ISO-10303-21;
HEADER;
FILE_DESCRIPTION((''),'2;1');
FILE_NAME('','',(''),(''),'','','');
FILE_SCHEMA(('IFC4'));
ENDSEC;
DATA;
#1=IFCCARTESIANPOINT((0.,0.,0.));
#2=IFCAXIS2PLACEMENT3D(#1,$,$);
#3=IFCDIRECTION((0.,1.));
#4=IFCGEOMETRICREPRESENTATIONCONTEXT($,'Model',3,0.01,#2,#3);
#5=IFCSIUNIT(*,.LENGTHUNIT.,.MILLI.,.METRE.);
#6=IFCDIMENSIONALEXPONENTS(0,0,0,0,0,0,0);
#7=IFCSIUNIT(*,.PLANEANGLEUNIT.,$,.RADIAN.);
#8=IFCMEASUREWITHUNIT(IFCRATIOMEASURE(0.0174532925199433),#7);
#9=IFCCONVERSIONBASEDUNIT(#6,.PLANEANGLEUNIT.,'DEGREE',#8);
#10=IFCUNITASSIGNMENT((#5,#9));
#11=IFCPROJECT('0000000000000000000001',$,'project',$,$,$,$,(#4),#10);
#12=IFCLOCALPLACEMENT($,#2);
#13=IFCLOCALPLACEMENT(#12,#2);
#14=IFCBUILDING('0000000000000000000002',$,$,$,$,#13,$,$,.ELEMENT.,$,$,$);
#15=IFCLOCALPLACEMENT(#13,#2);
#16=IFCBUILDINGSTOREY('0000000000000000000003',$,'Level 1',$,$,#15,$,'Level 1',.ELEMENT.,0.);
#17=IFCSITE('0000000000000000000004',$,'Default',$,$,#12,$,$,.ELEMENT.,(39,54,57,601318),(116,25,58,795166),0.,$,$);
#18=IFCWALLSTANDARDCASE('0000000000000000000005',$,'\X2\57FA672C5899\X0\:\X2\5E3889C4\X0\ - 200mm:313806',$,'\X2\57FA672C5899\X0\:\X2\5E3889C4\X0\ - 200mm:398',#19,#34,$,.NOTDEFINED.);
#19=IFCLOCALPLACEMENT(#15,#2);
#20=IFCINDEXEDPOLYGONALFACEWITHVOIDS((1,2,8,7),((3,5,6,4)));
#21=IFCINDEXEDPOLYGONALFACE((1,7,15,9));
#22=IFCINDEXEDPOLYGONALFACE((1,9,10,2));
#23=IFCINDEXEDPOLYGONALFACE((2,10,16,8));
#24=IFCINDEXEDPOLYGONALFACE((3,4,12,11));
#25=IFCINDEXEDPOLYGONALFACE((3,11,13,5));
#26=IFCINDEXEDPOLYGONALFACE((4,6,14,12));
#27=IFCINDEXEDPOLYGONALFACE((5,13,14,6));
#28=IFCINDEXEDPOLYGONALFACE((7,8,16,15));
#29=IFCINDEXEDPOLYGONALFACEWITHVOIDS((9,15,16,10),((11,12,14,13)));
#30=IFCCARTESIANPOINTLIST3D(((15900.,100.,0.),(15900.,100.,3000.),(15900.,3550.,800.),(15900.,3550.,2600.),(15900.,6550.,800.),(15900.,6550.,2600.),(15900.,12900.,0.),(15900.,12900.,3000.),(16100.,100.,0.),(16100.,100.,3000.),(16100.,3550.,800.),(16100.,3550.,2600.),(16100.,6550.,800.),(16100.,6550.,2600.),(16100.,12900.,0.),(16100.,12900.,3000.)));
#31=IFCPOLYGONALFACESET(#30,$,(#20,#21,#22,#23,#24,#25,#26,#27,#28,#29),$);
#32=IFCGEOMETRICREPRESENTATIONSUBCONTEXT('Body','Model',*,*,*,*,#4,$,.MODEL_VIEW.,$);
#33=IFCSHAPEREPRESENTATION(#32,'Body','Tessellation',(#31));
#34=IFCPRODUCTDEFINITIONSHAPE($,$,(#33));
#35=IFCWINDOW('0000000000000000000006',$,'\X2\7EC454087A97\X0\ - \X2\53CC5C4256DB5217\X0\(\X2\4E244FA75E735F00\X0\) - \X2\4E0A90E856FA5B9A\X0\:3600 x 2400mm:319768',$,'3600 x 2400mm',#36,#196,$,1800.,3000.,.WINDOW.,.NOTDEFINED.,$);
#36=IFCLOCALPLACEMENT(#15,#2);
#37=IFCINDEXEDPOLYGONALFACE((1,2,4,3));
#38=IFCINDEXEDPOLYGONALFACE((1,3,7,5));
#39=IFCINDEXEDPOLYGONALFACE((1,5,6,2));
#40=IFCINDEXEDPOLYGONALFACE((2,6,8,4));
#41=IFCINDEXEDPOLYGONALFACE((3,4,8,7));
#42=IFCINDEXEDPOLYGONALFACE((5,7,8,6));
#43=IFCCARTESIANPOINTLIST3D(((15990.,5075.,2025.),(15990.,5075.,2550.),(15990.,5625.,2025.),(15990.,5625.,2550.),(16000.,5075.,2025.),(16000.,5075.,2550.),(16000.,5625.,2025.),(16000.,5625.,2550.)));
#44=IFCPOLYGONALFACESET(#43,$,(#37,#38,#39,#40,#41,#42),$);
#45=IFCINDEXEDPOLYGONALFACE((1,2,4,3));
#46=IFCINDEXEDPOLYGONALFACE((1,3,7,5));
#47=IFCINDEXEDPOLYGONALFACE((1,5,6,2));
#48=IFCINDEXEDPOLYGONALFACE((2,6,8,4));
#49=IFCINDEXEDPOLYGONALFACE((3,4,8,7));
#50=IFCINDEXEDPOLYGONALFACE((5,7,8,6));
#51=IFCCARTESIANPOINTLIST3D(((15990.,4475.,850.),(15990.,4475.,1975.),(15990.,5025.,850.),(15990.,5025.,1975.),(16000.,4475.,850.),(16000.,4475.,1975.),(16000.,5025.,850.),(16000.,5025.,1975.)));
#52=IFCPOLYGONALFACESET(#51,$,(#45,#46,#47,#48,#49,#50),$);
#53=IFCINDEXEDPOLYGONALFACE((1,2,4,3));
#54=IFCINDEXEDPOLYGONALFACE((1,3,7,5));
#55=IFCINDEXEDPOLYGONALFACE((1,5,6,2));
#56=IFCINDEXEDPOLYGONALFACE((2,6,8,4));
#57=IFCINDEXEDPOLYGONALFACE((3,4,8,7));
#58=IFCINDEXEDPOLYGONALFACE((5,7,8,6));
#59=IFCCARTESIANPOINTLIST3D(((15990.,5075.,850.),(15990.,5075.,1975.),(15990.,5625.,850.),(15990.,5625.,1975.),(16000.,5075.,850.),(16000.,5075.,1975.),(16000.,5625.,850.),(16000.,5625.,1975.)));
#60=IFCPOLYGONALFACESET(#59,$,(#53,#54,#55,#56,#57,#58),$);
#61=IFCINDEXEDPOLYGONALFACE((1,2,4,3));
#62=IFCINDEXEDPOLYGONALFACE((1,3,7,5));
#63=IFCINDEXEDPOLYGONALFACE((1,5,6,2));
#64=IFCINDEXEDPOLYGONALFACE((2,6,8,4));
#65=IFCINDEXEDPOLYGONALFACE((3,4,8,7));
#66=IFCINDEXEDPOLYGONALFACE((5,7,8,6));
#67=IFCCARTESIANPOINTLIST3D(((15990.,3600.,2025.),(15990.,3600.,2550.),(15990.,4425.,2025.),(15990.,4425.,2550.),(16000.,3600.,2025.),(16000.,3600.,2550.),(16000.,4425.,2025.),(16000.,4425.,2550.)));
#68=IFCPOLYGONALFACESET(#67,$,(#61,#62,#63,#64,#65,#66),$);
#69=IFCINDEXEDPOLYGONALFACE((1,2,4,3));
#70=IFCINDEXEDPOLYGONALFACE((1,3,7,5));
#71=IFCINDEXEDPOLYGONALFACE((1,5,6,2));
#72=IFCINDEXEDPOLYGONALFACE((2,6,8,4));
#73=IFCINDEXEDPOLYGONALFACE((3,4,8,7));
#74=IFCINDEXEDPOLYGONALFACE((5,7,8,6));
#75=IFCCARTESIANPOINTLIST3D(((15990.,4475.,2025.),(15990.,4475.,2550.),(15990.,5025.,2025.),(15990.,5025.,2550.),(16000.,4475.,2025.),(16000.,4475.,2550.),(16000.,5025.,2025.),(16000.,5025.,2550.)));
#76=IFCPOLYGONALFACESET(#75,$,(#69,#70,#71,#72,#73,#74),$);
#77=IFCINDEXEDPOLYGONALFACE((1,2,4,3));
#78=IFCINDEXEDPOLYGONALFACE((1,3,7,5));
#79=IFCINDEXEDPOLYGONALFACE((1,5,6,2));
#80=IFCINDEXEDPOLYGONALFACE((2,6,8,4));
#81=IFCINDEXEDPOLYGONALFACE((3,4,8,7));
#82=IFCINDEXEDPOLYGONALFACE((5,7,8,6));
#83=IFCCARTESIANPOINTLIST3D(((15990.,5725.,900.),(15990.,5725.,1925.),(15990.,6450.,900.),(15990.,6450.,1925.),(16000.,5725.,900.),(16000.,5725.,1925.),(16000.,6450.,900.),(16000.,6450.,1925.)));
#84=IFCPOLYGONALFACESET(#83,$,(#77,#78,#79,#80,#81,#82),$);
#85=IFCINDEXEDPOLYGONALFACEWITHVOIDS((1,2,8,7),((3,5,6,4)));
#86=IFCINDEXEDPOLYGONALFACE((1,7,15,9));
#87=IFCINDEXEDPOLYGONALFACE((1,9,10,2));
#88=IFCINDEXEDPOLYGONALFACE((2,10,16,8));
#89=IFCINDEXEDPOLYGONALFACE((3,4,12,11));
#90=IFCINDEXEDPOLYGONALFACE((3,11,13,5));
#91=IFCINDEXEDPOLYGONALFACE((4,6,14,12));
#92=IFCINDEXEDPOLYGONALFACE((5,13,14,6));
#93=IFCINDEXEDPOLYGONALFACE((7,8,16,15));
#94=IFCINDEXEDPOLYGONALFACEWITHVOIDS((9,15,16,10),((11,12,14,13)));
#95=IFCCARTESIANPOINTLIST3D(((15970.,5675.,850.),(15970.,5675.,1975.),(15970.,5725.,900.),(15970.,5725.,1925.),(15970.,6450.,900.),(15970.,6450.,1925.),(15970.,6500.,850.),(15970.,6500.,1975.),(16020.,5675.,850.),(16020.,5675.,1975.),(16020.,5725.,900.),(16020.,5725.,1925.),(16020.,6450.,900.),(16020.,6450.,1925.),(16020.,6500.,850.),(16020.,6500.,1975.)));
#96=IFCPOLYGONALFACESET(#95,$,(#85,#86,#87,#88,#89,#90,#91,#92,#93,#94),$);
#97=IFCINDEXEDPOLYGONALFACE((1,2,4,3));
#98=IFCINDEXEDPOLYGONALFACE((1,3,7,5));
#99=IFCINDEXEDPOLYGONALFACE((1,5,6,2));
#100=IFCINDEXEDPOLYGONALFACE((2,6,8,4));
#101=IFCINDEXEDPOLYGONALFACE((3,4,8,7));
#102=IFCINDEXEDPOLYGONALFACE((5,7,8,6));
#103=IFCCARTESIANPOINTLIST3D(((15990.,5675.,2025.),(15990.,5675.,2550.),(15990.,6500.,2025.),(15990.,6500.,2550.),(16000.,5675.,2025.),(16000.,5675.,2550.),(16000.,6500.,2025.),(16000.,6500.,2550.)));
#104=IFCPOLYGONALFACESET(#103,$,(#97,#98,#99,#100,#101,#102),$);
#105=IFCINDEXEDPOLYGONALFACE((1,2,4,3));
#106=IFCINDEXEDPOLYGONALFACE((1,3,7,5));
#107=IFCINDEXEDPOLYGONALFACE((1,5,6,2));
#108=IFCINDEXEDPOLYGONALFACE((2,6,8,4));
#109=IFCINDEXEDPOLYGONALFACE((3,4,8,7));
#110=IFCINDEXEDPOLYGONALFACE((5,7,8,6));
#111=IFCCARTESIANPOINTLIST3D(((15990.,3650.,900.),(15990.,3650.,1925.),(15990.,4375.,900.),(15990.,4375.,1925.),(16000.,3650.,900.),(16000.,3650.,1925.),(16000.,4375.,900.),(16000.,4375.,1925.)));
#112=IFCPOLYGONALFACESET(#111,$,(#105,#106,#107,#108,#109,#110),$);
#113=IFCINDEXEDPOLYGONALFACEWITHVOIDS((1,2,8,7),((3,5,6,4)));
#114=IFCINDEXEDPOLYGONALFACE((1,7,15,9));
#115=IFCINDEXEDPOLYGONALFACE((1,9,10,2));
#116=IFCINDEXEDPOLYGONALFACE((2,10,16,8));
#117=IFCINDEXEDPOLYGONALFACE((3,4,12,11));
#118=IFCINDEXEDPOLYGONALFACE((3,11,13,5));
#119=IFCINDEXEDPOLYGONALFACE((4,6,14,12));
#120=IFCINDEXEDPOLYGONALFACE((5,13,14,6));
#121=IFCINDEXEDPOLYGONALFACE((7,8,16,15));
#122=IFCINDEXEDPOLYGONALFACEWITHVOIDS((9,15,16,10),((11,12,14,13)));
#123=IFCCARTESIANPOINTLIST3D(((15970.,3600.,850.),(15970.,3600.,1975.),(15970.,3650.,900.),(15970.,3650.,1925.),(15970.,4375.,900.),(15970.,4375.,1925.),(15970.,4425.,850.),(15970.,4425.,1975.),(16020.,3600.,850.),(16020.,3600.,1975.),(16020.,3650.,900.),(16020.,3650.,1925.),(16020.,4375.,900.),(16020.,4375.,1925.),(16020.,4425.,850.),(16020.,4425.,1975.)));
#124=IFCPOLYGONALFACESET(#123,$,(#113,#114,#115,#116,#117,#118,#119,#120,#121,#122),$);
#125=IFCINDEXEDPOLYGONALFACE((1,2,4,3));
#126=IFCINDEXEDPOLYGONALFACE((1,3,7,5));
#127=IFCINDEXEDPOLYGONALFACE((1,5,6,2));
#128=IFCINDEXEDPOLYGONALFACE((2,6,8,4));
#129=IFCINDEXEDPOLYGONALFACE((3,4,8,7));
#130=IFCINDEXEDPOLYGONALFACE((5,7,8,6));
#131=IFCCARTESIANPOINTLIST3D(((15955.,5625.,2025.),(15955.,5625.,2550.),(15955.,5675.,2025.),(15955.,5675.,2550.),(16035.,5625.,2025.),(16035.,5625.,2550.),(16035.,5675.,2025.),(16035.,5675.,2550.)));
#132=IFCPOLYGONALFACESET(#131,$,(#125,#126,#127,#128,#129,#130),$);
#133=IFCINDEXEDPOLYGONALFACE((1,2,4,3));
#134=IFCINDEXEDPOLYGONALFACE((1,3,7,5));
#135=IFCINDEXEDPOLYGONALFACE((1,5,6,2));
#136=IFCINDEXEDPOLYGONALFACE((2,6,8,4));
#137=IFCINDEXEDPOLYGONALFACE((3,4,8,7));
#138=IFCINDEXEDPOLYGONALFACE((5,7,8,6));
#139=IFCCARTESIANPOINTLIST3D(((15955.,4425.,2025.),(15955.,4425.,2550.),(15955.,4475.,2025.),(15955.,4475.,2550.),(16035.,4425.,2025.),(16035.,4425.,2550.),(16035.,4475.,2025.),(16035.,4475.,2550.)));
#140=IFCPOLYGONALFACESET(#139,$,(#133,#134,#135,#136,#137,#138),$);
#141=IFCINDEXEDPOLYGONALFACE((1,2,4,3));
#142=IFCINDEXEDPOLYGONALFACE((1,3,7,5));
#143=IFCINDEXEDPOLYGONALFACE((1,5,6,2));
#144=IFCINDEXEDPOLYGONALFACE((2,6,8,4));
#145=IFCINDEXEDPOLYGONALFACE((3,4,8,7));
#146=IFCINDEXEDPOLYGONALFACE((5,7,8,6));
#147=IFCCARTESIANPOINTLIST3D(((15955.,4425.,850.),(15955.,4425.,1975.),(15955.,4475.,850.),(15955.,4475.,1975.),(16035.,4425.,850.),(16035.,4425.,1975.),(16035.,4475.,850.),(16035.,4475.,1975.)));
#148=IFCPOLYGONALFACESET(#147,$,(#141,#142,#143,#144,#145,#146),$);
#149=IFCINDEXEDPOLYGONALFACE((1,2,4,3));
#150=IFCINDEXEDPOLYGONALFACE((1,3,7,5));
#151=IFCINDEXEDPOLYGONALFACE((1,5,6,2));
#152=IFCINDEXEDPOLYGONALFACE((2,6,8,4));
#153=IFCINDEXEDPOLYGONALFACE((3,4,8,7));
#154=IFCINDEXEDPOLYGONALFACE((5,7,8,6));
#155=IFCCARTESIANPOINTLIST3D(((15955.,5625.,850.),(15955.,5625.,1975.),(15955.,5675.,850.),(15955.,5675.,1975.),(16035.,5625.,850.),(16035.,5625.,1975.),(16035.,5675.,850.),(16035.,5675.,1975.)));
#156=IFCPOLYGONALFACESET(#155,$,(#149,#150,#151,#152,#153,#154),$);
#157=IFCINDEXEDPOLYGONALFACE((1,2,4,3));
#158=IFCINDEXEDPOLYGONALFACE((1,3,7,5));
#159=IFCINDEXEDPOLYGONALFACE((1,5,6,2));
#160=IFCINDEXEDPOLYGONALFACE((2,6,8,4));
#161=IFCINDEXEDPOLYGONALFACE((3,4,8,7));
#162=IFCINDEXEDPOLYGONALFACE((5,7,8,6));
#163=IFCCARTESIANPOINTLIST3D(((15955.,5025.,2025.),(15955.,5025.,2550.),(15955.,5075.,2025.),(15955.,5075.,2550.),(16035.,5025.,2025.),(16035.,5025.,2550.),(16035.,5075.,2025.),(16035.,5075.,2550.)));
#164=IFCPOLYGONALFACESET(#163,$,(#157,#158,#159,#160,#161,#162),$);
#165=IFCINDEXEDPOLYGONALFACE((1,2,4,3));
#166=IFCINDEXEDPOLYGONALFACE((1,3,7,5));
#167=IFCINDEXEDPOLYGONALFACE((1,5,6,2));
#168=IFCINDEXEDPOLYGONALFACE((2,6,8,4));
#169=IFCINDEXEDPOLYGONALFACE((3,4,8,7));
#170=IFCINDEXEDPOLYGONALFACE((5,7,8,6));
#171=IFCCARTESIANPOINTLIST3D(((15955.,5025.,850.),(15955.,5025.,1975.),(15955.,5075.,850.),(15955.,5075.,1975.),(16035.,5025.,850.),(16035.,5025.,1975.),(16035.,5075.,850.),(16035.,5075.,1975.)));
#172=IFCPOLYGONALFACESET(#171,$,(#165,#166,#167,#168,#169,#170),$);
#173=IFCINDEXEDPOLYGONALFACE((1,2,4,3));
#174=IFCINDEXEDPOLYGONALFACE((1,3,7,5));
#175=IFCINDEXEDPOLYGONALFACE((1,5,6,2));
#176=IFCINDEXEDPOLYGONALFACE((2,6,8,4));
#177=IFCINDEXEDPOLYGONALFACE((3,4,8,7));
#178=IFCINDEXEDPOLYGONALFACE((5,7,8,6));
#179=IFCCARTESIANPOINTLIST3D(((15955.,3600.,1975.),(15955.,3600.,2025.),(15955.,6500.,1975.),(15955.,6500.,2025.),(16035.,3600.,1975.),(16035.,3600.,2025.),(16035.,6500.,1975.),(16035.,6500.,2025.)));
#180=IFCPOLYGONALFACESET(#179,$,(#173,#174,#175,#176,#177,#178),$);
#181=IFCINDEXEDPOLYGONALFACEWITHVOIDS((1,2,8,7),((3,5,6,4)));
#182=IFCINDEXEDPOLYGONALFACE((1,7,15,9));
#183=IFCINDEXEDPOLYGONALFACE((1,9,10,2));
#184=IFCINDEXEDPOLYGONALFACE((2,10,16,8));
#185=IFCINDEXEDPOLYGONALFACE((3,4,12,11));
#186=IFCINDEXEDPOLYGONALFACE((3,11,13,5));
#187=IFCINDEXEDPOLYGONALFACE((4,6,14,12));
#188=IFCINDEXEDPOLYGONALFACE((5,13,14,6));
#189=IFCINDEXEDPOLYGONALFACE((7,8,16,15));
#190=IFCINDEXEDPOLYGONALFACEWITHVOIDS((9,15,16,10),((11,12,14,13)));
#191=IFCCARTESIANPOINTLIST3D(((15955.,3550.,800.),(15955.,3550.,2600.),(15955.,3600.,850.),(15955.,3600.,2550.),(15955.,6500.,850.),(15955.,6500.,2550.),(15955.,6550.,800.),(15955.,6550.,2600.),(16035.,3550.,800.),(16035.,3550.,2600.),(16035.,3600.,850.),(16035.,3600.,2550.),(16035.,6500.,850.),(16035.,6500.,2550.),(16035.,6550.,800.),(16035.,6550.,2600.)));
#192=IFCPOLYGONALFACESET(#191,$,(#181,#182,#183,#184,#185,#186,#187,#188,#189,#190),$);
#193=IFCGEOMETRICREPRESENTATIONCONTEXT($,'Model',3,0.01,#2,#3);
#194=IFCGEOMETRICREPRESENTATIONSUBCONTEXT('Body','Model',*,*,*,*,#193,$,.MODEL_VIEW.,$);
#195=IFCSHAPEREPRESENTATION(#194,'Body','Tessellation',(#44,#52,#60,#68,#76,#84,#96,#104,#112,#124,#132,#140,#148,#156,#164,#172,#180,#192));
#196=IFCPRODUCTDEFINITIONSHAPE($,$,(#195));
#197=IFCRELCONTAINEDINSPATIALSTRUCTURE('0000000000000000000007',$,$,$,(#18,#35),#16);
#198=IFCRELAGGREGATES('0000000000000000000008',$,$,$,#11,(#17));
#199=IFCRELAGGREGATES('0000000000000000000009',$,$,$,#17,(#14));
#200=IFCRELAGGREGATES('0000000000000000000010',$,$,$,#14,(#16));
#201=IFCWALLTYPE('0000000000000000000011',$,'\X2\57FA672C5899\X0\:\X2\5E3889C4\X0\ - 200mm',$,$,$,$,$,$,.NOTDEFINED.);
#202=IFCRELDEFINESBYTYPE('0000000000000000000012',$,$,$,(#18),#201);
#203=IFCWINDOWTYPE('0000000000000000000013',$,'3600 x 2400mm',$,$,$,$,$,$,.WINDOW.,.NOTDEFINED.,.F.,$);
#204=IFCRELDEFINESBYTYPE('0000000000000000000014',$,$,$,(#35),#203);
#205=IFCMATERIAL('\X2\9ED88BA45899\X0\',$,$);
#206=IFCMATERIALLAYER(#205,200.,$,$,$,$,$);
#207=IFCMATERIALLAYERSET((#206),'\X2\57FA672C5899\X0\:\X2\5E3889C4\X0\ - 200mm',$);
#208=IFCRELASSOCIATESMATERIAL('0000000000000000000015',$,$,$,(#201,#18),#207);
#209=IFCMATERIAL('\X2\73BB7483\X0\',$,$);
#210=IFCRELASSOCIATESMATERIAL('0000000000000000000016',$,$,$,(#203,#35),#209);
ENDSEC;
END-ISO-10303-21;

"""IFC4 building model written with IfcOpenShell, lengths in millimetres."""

from ifc_helpers import new_model, entity, si_unit, converted_unit, direction, frame, frame_2d, origin, origin_2d_with_axis, place, context, subcontext, project, spatial, polyline, rectangle, outline, extrude, source, transform, mapped, material, layer, layer_set, layer_usage, type_object, type_shapes, element, fill, save


model = new_model("IFC4")

# Units and contexts
model_context_1 = context("Model", 3, precision=0.01, world=origin(), true_north=direction((0.0, 1.0)))
model_context_2 = context("Model", 3, precision=0.01, world=origin(), true_north=direction((0.0, 1.0)))
body_context_1 = subcontext(model_context_1, "Body", "Model", "MODEL_VIEW")
body_context_2 = subcontext(model_context_2, "Body", "Model", "MODEL_VIEW")
ifc_project = project(units=[si_unit("LENGTHUNIT", "METRE", prefix="MILLI"), converted_unit("PLANEANGLEUNIT", "DEGREE", entity("IfcRatioMeasure", 0.0174532925199433), si_unit("PLANEANGLEUNIT", "RADIAN"), dimensions=[0, 0, 0, 0, 0, 0, 0])], contexts=[model_context_1])

# Site, building, storey
site_placement = place(None, origin())
site = spatial("IfcSite", under=ifc_project, at=site_placement, Name="Default", CompositionType="ELEMENT", RefLatitude=(39, 54, 57, 601318), RefLongitude=(116, 25, 58, 795166), RefElevation=0.0)
building_placement = place(site_placement, origin())
building = spatial("IfcBuilding", under=site, at=building_placement, CompositionType="ELEMENT")
storey_placement = place(building_placement, origin())
storey = spatial("IfcBuildingStorey", under=building, at=storey_placement, Name="Level 1", LongName="Level 1", CompositionType="ELEMENT", Elevation=0.0)

# Shared definitions
ifc_material_1 = material(Name="默认墙")
ifc_layer_1 = layer(ifc_material_1, 200.0)
ifc_layer_set_1 = layer_set([ifc_layer_1], Name="基本墙:常规 - 200mm")
wall_type_1 = type_object("IfcWallType", Name="基本墙:常规 - 200mm", PredefinedType="NOTDEFINED", material=ifc_layer_set_1)
placement_1 = place(None, origin())
placement_2 = place(placement_1, origin())
placement_3 = place(placement_2, origin())
ifc_material_2 = material(Name="玻璃")
window_type = type_object("IfcWindowType", Name="3600 x 2400mm", ParameterTakesPrecedence=False, PartitioningType="NOTDEFINED", PredefinedType="WINDOW", material=ifc_material_2)
shared_shape_1 = source(origin(), body_context_2, "Body", "SweptSolid", [
    extrude(rectangle(XDim=10.0, YDim=550.0, at=origin_2d_with_axis()), frame((1200.0, 95.0, 1225.0), z_axis=(0.0, 0.0, 1.0), x_axis=(0.0, 1.0, 0.0)), (0.0, 0.0, 1.0), 525.0),
    extrude(rectangle(XDim=10.0, YDim=550.0, at=origin_2d_with_axis()), frame((1800.0, 95.0, 50.0), z_axis=(0.0, 0.0, 1.0), x_axis=(0.0, 1.0, 0.0)), (0.0, 0.0, 1.0), 1125.0),
    extrude(rectangle(XDim=10.0, YDim=550.0, at=origin_2d_with_axis()), frame((1200.0, 95.0, 50.0), z_axis=(0.0, 0.0, 1.0), x_axis=(0.0, 1.0, 0.0)), (0.0, 0.0, 1.0), 1125.0),
    extrude(rectangle(XDim=10.0, YDim=825.0, at=origin_2d_with_axis()), frame((2537.5, 95.0, 1225.0), z_axis=(0.0, 0.0, 1.0), x_axis=(0.0, 1.0, 0.0)), (0.0, 0.0, 1.0), 525.0),
    extrude(rectangle(XDim=10.0, YDim=550.0, at=origin_2d_with_axis()), frame((1800.0, 95.0, 1225.0), z_axis=(0.0, 0.0, 1.0), x_axis=(0.0, 1.0, 0.0)), (0.0, 0.0, 1.0), 525.0),
    extrude(rectangle(XDim=10.0, YDim=725.0, at=origin_2d_with_axis()), frame((462.5, 95.0, 100.0), z_axis=(0.0, 0.0, 1.0), x_axis=(0.0, 1.0, 0.0)), (0.0, 0.0, 1.0), 1025.0),
    extrude(outline(polyline([(-562.5, -412.5), (562.5, -412.5), (562.5, 412.5), (-562.5, 412.5), (-562.5, -412.5)]), holes=[polyline([(512.5, -362.5), (-512.5, -362.5), (-512.5, 362.5), (512.5, 362.5), (512.5, -362.5)])]), frame((462.5, 70.0, 612.5), z_axis=(0.0, 1.0, 0.0), x_axis=(0.0, 0.0, -1.0)), (0.0, 0.0, 1.0), 50.0),
    extrude(rectangle(XDim=10.0, YDim=825.0, at=origin_2d_with_axis()), frame((462.5, 95.0, 1225.0), z_axis=(0.0, 0.0, 1.0), x_axis=(0.0, 1.0, 0.0)), (0.0, 0.0, 1.0), 525.0),
    extrude(rectangle(XDim=10.0, YDim=725.0, at=origin_2d_with_axis()), frame((2537.5, 95.0, 100.0), z_axis=(0.0, 0.0, 1.0), x_axis=(0.0, 1.0, 0.0)), (0.0, 0.0, 1.0), 1025.0),
    extrude(outline(polyline([(-562.5, -412.5), (562.5, -412.5), (562.5, 412.5), (-562.5, 412.5), (-562.5, -412.5)]), holes=[polyline([(512.5, -362.5), (-512.5, -362.5), (-512.5, 362.5), (512.5, 362.5), (512.5, -362.5)])]), frame((2537.5, 70.0, 612.5), z_axis=(0.0, 1.0, 0.0), x_axis=(0.0, 0.0, -1.0)), (0.0, 0.0, 1.0), 50.0),
    extrude(rectangle(XDim=80.0, YDim=50.0, at=origin_2d_with_axis()), frame((900.0, 95.0, 1225.0), z_axis=(0.0, 0.0, 1.0), x_axis=(0.0, -1.0, 0.0)), (0.0, 0.0, 1.0), 525.0),
    extrude(rectangle(XDim=80.0, YDim=50.0, at=origin_2d_with_axis()), frame((2100.0, 95.0, 1225.0), z_axis=(0.0, 0.0, 1.0), x_axis=(0.0, -1.0, 0.0)), (0.0, 0.0, 1.0), 525.0),
    extrude(rectangle(XDim=80.0, YDim=50.0, at=origin_2d_with_axis()), frame((2100.0, 95.0, 50.0), z_axis=(0.0, 0.0, 1.0), x_axis=(0.0, -1.0, 0.0)), (0.0, 0.0, 1.0), 1125.0),
    extrude(rectangle(XDim=80.0, YDim=50.0, at=origin_2d_with_axis()), frame((900.0, 95.0, 50.0), z_axis=(0.0, 0.0, 1.0), x_axis=(0.0, -1.0, 0.0)), (0.0, 0.0, 1.0), 1125.0),
    extrude(rectangle(XDim=80.0, YDim=50.0, at=origin_2d_with_axis()), frame((1500.0, 95.0, 1225.0), z_axis=(0.0, 0.0, 1.0), x_axis=(0.0, -1.0, 0.0)), (0.0, 0.0, 1.0), 525.0),
    extrude(rectangle(XDim=80.0, YDim=50.0, at=origin_2d_with_axis()), frame((1500.0, 95.0, 50.0), z_axis=(0.0, 0.0, 1.0), x_axis=(0.0, -1.0, 0.0)), (0.0, 0.0, 1.0), 1125.0),
    extrude(rectangle(XDim=80.0, YDim=2900.0, at=origin_2d_with_axis()), frame((1500.0, 95.0, 1175.0), z_axis=(0.0, 0.0, 1.0), x_axis=(0.0, -1.0, 0.0)), (0.0, 0.0, 1.0), 50.0),
    extrude(outline(polyline([(-1500.0, -900.0), (1500.0, -900.0), (1500.0, 900.0), (-1500.0, 900.0), (-1500.0, -900.0)]), holes=[polyline([(1450.0, -850.0), (-1450.0, -850.0), (-1450.0, 850.0), (1450.0, 850.0), (1450.0, -850.0)])]), frame((1500.0, 55.0, 900.0), z_axis=(0.0, 1.0, 0.0), x_axis=(1.0, 0.0, 0.0)), (0.0, 0.0, 1.0), 80.0),
])
type_shapes(window_type, [shared_shape_1])

# Wall, opening, window
ifc_layer_usage_1 = layer_usage(ifc_layer_set_1, "AXIS2", "NEGATIVE", 100.0)
wall_1_placement = place(storey_placement, frame((16000.0, 12900.0, 0.0), z_axis=(0.0, 0.0, 1.0), x_axis=(0.0, -1.0, 0.0)))
wall_1 = element("IfcWallStandardCase", 1, at=wall_1_placement, inside=storey, type_object=wall_type_1, material=ifc_layer_usage_1, Name="基本墙:常规 - 200mm:313806", ObjectType="基本墙:常规 - 200mm:398", PredefinedType="NOTDEFINED", context=body_context_1, shape_type="SweptSolid", body=[
    extrude(rectangle(XDim=12800.0, YDim=200.0, at=frame_2d((6400.0, 0.0), x_axis=(-1.0, 0.0))), origin(), (0.0, 0.0, 1.0), 3000.0),
])
placement_4 = place(placement_3, frame((16000.0, 12900.0, 0.0), z_axis=(0.0, 0.0, 1.0), x_axis=(0.0, -1.0, 0.0)))
opening_1_placement = place(placement_4, frame((6350.0, -100.0, 800.0)))
opening_1 = element("IfcOpeningElement", 2, at=opening_1_placement, cuts=wall_1, ObjectType="Opening", PredefinedType="OPENING", context=body_context_2, shape_type="SweptSolid", body=[
    extrude(rectangle(XDim=1800.0, YDim=3000.0, at=frame_2d((900.0, 1500.0), x_axis=(1.0, 0.0))), frame((0.0, 0.0, 0.0), z_axis=(0.0, 1.0, 0.0), x_axis=(0.0, 0.0, 1.0)), (0.0, 0.0, 1.0), 200.0),
])
window_1_placement = place(opening_1_placement, origin())
window_1 = element("IfcWindow", 3, at=window_1_placement, inside=storey, type_object=window_type, material=ifc_material_2, Name="组合窗 - 双层四列(两侧平开) - 上部固定:3600 x 2400mm:319768", ObjectType="3600 x 2400mm", OverallHeight=1800.0, OverallWidth=3000.0, PartitioningType="NOTDEFINED", PredefinedType="WINDOW", context=body_context_2, shape_type="MappedRepresentation", body=[
    mapped(shared_shape_1, transform((0.0, 0.0, 0.0), scale=1.0)),
])
fill(opening_1, window_1)

save(model, "model.ifc")
